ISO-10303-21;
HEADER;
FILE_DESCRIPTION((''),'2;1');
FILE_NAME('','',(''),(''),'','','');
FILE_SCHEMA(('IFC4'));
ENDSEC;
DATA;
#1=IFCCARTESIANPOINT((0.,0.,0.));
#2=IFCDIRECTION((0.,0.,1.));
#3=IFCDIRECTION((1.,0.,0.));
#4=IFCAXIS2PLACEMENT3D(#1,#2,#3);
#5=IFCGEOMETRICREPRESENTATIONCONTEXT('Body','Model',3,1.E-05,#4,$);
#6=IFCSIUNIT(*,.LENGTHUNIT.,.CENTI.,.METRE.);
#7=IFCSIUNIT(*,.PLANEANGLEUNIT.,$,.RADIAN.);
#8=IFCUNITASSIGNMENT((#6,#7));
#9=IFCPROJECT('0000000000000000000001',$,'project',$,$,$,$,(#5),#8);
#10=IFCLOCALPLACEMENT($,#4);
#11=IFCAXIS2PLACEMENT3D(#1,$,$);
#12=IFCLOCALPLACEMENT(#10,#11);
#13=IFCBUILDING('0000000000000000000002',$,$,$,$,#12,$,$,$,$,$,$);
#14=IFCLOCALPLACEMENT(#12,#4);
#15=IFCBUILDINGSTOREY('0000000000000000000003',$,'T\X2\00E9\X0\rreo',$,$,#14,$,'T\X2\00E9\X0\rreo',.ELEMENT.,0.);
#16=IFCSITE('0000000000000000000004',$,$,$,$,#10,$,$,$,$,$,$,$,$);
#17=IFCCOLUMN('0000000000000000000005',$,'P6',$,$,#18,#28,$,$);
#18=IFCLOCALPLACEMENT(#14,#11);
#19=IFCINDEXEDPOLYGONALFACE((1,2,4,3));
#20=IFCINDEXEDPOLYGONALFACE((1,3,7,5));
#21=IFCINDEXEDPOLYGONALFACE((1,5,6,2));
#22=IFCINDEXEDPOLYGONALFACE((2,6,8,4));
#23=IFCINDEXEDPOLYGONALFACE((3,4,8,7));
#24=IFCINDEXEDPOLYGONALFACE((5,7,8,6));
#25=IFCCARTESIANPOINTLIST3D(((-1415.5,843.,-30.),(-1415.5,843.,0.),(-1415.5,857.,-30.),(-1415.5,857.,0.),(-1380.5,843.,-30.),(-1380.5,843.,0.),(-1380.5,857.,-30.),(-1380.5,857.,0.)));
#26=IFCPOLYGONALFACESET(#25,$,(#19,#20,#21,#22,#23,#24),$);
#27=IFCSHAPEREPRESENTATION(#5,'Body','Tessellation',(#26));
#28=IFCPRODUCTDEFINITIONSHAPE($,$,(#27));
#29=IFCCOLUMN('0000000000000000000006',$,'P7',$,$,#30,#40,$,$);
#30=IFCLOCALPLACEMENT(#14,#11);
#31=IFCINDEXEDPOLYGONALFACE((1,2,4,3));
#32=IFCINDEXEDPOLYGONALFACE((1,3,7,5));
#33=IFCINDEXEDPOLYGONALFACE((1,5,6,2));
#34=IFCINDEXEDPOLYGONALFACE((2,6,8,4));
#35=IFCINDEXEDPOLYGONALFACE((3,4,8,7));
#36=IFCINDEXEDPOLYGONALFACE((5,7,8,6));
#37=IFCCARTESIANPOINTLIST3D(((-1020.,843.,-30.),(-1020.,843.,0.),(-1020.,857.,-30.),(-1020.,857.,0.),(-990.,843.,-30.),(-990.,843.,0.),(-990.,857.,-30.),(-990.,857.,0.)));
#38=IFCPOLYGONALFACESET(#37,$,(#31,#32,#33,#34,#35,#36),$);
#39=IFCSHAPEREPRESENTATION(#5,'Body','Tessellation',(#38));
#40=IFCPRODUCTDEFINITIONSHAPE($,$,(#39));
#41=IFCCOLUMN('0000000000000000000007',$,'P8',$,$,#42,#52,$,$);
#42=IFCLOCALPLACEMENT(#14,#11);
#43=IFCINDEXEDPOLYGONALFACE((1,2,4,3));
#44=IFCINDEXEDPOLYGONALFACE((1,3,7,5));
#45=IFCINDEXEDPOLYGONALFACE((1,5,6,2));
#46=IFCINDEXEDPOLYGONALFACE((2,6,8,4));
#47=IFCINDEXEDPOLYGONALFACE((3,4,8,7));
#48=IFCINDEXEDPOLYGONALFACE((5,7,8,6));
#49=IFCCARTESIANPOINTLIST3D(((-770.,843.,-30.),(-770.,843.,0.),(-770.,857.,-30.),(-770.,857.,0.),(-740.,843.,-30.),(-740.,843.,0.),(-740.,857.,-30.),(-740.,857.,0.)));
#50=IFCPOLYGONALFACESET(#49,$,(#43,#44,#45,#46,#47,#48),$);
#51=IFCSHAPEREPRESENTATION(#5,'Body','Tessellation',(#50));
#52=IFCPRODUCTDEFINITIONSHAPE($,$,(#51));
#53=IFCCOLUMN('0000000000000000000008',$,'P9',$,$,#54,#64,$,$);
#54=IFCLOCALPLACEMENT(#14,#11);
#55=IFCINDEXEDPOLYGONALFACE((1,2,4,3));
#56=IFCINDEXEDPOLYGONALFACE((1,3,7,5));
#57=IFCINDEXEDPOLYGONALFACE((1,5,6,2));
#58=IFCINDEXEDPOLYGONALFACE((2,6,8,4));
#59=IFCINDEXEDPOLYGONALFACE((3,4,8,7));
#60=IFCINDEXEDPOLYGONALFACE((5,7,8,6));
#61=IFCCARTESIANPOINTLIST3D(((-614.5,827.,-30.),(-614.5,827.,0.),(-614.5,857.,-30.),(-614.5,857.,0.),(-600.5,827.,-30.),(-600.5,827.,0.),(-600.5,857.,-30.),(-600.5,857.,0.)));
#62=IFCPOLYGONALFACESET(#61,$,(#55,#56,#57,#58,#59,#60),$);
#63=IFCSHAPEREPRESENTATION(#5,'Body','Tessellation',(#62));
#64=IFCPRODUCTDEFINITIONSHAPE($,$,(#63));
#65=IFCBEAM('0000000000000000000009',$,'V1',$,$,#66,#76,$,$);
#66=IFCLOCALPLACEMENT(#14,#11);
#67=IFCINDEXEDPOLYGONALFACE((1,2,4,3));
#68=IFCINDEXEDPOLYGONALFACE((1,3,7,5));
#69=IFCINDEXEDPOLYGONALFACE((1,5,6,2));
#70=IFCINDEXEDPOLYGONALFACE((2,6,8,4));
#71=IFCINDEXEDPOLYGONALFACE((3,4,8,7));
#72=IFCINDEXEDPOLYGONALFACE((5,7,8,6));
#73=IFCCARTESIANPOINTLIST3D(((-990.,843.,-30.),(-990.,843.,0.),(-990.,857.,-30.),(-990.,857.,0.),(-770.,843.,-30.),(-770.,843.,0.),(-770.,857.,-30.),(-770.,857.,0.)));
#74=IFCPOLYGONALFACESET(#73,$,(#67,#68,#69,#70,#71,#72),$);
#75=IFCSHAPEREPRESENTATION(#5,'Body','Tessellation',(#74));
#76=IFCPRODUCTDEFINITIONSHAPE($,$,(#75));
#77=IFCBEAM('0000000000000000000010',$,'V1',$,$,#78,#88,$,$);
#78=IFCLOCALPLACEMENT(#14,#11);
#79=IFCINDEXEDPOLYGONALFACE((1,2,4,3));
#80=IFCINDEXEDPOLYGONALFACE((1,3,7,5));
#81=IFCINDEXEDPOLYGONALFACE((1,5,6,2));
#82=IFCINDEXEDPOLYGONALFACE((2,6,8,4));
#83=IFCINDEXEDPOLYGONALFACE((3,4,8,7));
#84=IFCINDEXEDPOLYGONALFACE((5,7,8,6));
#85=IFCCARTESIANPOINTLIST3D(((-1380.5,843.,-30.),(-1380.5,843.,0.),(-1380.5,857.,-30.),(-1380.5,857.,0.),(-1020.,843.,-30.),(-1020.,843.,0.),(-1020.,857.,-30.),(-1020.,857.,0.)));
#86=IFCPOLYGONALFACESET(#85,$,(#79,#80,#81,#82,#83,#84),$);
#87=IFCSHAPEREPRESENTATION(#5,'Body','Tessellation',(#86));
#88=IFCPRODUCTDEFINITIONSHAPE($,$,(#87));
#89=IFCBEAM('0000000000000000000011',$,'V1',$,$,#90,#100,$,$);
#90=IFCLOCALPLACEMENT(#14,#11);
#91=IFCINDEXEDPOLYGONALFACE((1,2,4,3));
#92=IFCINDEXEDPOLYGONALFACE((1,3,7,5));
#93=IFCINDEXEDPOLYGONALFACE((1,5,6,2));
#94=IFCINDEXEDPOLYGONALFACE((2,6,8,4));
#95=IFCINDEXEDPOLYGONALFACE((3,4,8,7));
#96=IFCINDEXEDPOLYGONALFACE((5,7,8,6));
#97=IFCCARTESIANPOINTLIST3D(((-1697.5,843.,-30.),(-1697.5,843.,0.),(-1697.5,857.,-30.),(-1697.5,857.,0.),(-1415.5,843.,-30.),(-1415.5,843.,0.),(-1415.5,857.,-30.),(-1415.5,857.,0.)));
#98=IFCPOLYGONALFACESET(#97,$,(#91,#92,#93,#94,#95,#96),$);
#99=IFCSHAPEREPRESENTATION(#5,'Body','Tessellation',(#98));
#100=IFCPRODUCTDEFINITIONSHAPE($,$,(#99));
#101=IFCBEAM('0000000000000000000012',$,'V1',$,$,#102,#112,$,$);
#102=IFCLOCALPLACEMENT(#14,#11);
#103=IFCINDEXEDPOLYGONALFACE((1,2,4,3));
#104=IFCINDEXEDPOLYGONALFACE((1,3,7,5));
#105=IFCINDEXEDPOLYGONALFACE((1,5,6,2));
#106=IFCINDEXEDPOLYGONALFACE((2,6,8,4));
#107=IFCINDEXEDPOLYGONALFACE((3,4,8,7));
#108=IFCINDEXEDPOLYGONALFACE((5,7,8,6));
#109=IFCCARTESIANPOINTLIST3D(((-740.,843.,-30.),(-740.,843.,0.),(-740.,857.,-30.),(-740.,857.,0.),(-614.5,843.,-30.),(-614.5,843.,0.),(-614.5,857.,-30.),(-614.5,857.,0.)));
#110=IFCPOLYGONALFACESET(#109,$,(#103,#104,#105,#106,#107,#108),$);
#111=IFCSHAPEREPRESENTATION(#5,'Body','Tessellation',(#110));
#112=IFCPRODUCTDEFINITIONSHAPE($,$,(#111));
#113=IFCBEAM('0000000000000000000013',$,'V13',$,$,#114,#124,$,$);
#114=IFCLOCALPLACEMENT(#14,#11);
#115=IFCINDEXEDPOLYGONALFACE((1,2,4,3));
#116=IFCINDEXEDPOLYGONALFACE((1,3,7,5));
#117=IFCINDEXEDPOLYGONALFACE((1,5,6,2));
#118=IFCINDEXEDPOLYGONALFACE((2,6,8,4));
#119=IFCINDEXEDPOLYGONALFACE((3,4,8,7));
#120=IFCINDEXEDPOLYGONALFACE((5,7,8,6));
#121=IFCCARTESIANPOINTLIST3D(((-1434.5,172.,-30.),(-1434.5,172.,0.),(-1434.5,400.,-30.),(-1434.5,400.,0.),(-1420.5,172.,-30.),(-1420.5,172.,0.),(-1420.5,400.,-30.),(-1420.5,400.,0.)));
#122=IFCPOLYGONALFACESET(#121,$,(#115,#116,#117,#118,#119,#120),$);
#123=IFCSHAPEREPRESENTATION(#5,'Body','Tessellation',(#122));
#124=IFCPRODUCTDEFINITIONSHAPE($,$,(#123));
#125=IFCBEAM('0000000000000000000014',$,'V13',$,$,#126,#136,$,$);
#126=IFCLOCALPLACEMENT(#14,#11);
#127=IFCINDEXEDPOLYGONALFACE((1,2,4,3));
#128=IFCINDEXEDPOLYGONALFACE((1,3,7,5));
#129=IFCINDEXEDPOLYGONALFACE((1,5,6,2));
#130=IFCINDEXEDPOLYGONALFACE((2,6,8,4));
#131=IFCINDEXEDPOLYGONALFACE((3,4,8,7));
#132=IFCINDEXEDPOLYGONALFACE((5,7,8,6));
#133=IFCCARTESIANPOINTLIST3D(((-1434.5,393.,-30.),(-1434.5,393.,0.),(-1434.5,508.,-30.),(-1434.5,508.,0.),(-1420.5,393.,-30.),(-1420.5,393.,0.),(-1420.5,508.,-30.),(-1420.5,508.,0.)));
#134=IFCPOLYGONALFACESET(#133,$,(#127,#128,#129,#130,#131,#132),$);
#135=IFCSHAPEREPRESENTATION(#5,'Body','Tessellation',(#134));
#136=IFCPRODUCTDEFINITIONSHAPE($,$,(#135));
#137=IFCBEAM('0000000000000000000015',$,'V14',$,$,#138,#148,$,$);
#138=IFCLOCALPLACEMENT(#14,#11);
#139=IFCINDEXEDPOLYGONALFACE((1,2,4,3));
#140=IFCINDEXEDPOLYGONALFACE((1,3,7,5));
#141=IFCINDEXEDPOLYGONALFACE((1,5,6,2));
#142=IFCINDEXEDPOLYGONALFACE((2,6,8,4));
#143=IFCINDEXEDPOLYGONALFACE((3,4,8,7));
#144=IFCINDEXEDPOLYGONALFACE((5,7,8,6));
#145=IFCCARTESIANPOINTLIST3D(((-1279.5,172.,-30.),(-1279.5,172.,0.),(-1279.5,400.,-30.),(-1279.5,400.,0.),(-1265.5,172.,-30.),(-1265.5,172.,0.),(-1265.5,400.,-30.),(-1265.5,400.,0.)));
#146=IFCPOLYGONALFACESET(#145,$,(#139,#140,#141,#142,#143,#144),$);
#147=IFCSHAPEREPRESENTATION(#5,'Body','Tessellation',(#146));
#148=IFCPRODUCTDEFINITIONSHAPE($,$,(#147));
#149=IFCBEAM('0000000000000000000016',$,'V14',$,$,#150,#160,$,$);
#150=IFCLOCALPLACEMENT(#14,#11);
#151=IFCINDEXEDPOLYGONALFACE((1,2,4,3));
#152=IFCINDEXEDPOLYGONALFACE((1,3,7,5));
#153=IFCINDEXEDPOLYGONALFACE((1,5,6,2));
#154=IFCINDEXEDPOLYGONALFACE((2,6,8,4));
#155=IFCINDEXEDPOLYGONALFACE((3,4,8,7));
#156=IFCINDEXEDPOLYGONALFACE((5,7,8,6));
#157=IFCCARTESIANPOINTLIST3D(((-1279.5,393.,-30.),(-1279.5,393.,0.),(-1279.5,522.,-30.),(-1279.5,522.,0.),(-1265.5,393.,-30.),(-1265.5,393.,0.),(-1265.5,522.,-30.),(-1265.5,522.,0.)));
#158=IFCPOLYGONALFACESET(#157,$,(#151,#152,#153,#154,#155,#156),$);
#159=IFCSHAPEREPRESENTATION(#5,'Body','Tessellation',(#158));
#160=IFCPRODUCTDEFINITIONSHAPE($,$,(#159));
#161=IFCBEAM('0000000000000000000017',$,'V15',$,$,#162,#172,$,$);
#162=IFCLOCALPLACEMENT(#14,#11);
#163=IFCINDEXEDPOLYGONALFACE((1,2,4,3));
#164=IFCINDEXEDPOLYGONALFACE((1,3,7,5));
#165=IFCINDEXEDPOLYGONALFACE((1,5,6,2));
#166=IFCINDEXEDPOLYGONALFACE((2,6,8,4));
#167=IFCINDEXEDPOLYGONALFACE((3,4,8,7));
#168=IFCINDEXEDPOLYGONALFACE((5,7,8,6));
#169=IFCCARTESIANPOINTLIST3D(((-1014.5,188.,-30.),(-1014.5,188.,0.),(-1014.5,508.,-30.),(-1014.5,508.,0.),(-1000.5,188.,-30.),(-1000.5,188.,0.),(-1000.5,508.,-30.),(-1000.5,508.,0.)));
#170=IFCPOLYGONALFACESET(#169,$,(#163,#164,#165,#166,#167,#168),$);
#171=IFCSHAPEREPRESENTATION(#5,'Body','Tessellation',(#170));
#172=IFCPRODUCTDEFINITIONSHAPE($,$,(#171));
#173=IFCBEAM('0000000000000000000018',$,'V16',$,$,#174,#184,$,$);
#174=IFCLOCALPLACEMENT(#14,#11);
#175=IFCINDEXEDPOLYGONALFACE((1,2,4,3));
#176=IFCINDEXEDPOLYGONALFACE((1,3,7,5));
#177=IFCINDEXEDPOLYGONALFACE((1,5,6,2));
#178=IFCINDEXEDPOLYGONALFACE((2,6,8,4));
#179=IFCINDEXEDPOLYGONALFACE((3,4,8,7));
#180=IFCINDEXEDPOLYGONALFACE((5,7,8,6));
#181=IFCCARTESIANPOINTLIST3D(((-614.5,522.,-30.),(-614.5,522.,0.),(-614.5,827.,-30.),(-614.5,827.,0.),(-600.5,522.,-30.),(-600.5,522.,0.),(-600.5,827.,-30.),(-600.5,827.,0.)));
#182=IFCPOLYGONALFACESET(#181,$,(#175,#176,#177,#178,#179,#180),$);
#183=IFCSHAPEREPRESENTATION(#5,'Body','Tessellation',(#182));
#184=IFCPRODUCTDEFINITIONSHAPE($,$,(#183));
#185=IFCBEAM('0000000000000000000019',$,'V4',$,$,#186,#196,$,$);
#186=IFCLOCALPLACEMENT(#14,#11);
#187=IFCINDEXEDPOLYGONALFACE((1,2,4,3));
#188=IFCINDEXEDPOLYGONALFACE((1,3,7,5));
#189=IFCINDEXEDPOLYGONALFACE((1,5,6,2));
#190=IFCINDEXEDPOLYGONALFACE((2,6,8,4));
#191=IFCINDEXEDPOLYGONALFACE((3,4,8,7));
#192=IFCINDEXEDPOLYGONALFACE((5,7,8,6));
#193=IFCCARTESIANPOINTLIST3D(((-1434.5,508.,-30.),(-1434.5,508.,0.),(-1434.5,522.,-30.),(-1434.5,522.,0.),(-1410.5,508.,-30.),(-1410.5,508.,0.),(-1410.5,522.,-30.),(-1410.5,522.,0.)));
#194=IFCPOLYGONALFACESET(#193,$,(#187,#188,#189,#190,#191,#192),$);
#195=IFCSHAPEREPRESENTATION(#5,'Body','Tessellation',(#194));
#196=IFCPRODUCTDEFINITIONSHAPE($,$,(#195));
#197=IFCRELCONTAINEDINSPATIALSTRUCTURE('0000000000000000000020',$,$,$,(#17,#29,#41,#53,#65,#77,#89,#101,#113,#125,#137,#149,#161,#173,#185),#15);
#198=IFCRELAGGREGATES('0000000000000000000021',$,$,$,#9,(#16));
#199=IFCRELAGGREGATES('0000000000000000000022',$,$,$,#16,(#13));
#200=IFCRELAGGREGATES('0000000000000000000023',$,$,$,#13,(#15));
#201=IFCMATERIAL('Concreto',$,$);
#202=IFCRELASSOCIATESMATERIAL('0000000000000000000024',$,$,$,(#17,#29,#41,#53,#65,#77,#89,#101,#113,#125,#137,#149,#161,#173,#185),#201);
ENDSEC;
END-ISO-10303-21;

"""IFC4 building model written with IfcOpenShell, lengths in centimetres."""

from ifc_helpers import new_model, si_unit, frame, origin, origin_with_axes, origin_2d_with_axis, place, context, project, spatial, rectangle, extrude, material, element, save


model = new_model("IFC4")

# Units and contexts
model_context = context("Model", 3, precision=1e-05, world=origin_with_axes(), identifier="Body")
ifc_project = project(units=[si_unit("LENGTHUNIT", "METRE", prefix="CENTI"), si_unit("PLANEANGLEUNIT", "RADIAN")], contexts=[model_context])

# Site, building, storey
site_placement = place(None, origin_with_axes())
site = spatial("IfcSite", under=ifc_project, at=site_placement)
building_placement = place(site_placement, origin())
building = spatial("IfcBuilding", under=site, at=building_placement)
storey_placement = place(building_placement, origin_with_axes())
storey = spatial("IfcBuildingStorey", under=building, at=storey_placement, Name="Térreo", LongName="Térreo", CompositionType="ELEMENT", Elevation=0.0)

# Shared definitions
ifc_material = material(Name="Concreto")

# Columns
column_1_placement = place(storey_placement, frame((-1398.0, 850.0, 0.0), z_axis=(0.0, 0.0, 1.0), x_axis=(1.0, 0.0, 0.0)))
element("IfcColumn", 1, at=column_1_placement, inside=storey, material=ifc_material, Name="P6", context=model_context, shape_type="SolidModel", body=[
    extrude(rectangle(XDim=14.0, YDim=35.0, at=origin_2d_with_axis()), frame((0.0, 0.0, -30.0), z_axis=(0.0, 0.0, 1.0), x_axis=(0.0, 1.0, 0.0)), (0.0, 0.0, 1.0), 30.0),
])
for number, where, z_axis, x_axis, name in (
    (2, (-1005.0, 850.0, 0.0), (0.0, 0.0, 1.0), (1.0, 0.0, 0.0), "P7"),
    (3, (-755.0, 850.0, 0.0), (0.0, 0.0, 1.0), (1.0, 0.0, 0.0), "P8"),
):
    element("IfcColumn", number, at=place(storey_placement, frame(where, z_axis=z_axis, x_axis=x_axis)), inside=storey, material=ifc_material, Name=name, context=model_context, shape_type="SolidModel", body=[
        extrude(rectangle(XDim=14.0, YDim=30.0, at=origin_2d_with_axis()), frame((0.0, 0.0, -30.0), z_axis=(0.0, 0.0, 1.0), x_axis=(0.0, 1.0, 0.0)), (0.0, 0.0, 1.0), 30.0),
    ])
column_2_placement = place(storey_placement, frame((-607.5, 842.0, 0.0), z_axis=(0.0, 0.0, 1.0), x_axis=(1.0, 0.0, 0.0)))
element("IfcColumn", 4, at=column_2_placement, inside=storey, material=ifc_material, Name="P9", context=model_context, shape_type="SolidModel", body=[
    extrude(rectangle(XDim=14.0, YDim=30.0, at=origin_2d_with_axis()), frame((0.0, 0.0, -30.0), z_axis=(0.0, 0.0, 1.0), x_axis=(-1.0, 0.0, 0.0)), (0.0, 0.0, 1.0), 30.0),
])

# Beams
beam_1_placement = place(storey_placement, frame((-880.0, 850.0, 0.0), z_axis=(0.0, 0.0, 1.0), x_axis=(1.0, 0.0, 0.0)))
element("IfcBeam", 5, at=beam_1_placement, inside=storey, material=ifc_material, Name="V1", context=model_context, shape_type="SolidModel", body=[
    extrude(rectangle(XDim=14.0, YDim=30.0, at=origin_2d_with_axis()), frame((-110.0, 0.0, -15.0), z_axis=(1.0, 0.0, 0.0), x_axis=(0.0, 1.0, 0.0)), (0.0, 0.0, 1.0), 220.0),
])
beam_2_placement = place(storey_placement, frame((-1200.25, 850.0, 0.0), z_axis=(0.0, 0.0, 1.0), x_axis=(1.0, 0.0, 0.0)))
element("IfcBeam", 6, at=beam_2_placement, inside=storey, material=ifc_material, Name="V1", context=model_context, shape_type="SolidModel", body=[
    extrude(rectangle(XDim=14.0, YDim=30.0, at=origin_2d_with_axis()), frame((-180.25, 0.0, -15.0), z_axis=(1.0, 0.0, 0.0), x_axis=(0.0, -1.0, 0.0)), (0.0, 0.0, 1.0), 360.5),
])
beam_3_placement = place(storey_placement, frame((-1556.5, 850.0, 0.0), z_axis=(0.0, 0.0, 1.0), x_axis=(1.0, 0.0, 0.0)))
element("IfcBeam", 7, at=beam_3_placement, inside=storey, material=ifc_material, Name="V1", context=model_context, shape_type="SolidModel", body=[
    extrude(rectangle(XDim=14.0, YDim=30.0, at=origin_2d_with_axis()), frame((-141.0, 0.0, -15.0), z_axis=(1.0, 0.0, 0.0), x_axis=(0.0, -1.0, 0.0)), (0.0, 0.0, 1.0), 282.0),
])
beam_4_placement = place(storey_placement, frame((-677.25, 850.0, 0.0), z_axis=(0.0, 0.0, 1.0), x_axis=(1.0, 0.0, 0.0)))
element("IfcBeam", 8, at=beam_4_placement, inside=storey, material=ifc_material, Name="V1", context=model_context, shape_type="SolidModel", body=[
    extrude(rectangle(XDim=14.0, YDim=30.0, at=origin_2d_with_axis()), frame((-62.75, 0.0, -15.0), z_axis=(1.0, 0.0, 0.0), x_axis=(0.0, 1.0, 0.0)), (0.0, 0.0, 1.0), 125.5),
])
beam_5_placement = place(storey_placement, frame((-1427.5, 286.0, 0.0), z_axis=(0.0, 0.0, 1.0), x_axis=(1.0, 0.0, 0.0)))
element("IfcBeam", 9, at=beam_5_placement, inside=storey, material=ifc_material, Name="V13", context=model_context, shape_type="SolidModel", body=[
    extrude(rectangle(XDim=14.0, YDim=30.0, at=origin_2d_with_axis()), frame((0.0, -114.0, -15.0), z_axis=(0.0, 1.0, 0.0), x_axis=(-1.0, 0.0, 0.0)), (0.0, 0.0, 1.0), 228.0),
])
beam_6_placement = place(storey_placement, frame((-1427.5, 450.5, 0.0), z_axis=(0.0, 0.0, 1.0), x_axis=(1.0, 0.0, 0.0)))
element("IfcBeam", 10, at=beam_6_placement, inside=storey, material=ifc_material, Name="V13", context=model_context, shape_type="SolidModel", body=[
    extrude(rectangle(XDim=14.0, YDim=30.0, at=origin_2d_with_axis()), frame((0.0, -57.5, -15.0), z_axis=(0.0, 1.0, 0.0), x_axis=(-1.0, 0.0, 0.0)), (0.0, 0.0, 1.0), 115.0),
])
beam_7_placement = place(storey_placement, frame((-1272.5, 286.0, 0.0), z_axis=(0.0, 0.0, 1.0), x_axis=(1.0, 0.0, 0.0)))
element("IfcBeam", 11, at=beam_7_placement, inside=storey, material=ifc_material, Name="V14", context=model_context, shape_type="SolidModel", body=[
    extrude(rectangle(XDim=14.0, YDim=30.0, at=origin_2d_with_axis()), frame((0.0, -114.0, -15.0), z_axis=(0.0, 1.0, 0.0), x_axis=(-1.0, 0.0, 0.0)), (0.0, 0.0, 1.0), 228.0),
])
beam_8_placement = place(storey_placement, frame((-1272.5, 457.5, 0.0), z_axis=(0.0, 0.0, 1.0), x_axis=(1.0, 0.0, 0.0)))
element("IfcBeam", 12, at=beam_8_placement, inside=storey, material=ifc_material, Name="V14", context=model_context, shape_type="SolidModel", body=[
    extrude(rectangle(XDim=14.0, YDim=30.0, at=origin_2d_with_axis()), frame((0.0, -64.5, -15.0), z_axis=(0.0, 1.0, 0.0), x_axis=(-1.0, 0.0, 0.0)), (0.0, 0.0, 1.0), 129.0),
])
beam_9_placement = place(storey_placement, frame((-1007.5, 348.0, 0.0), z_axis=(0.0, 0.0, 1.0), x_axis=(1.0, 0.0, 0.0)))
element("IfcBeam", 13, at=beam_9_placement, inside=storey, material=ifc_material, Name="V15", context=model_context, shape_type="SolidModel", body=[
    extrude(rectangle(XDim=14.0, YDim=30.0, at=origin_2d_with_axis()), frame((0.0, -160.0, -15.0), z_axis=(0.0, 1.0, 0.0), x_axis=(-1.0, 0.0, 0.0)), (0.0, 0.0, 1.0), 320.0),
])
beam_10_placement = place(storey_placement, frame((-607.5, 674.5, 0.0), z_axis=(0.0, 0.0, 1.0), x_axis=(1.0, 0.0, 0.0)))
element("IfcBeam", 14, at=beam_10_placement, inside=storey, material=ifc_material, Name="V16", context=model_context, shape_type="SolidModel", body=[
    extrude(rectangle(XDim=14.0, YDim=30.0, at=origin_2d_with_axis()), frame((0.0, -152.5, -15.0), z_axis=(0.0, 1.0, 0.0), x_axis=(-1.0, 0.0, 0.0)), (0.0, 0.0, 1.0), 305.0),
])
beam_11_placement = place(storey_placement, frame((-1422.5, 515.0, 0.0), z_axis=(0.0, 0.0, 1.0), x_axis=(1.0, 0.0, 0.0)))
element("IfcBeam", 15, at=beam_11_placement, inside=storey, material=ifc_material, Name="V4", context=model_context, shape_type="SolidModel", body=[
    extrude(rectangle(XDim=14.0, YDim=30.0, at=origin_2d_with_axis()), frame((-12.0, 0.0, -15.0), z_axis=(1.0, 0.0, 0.0), x_axis=(0.0, -1.0, 0.0)), (0.0, 0.0, 1.0), 24.0),
])

save(model, "model.ifc")
